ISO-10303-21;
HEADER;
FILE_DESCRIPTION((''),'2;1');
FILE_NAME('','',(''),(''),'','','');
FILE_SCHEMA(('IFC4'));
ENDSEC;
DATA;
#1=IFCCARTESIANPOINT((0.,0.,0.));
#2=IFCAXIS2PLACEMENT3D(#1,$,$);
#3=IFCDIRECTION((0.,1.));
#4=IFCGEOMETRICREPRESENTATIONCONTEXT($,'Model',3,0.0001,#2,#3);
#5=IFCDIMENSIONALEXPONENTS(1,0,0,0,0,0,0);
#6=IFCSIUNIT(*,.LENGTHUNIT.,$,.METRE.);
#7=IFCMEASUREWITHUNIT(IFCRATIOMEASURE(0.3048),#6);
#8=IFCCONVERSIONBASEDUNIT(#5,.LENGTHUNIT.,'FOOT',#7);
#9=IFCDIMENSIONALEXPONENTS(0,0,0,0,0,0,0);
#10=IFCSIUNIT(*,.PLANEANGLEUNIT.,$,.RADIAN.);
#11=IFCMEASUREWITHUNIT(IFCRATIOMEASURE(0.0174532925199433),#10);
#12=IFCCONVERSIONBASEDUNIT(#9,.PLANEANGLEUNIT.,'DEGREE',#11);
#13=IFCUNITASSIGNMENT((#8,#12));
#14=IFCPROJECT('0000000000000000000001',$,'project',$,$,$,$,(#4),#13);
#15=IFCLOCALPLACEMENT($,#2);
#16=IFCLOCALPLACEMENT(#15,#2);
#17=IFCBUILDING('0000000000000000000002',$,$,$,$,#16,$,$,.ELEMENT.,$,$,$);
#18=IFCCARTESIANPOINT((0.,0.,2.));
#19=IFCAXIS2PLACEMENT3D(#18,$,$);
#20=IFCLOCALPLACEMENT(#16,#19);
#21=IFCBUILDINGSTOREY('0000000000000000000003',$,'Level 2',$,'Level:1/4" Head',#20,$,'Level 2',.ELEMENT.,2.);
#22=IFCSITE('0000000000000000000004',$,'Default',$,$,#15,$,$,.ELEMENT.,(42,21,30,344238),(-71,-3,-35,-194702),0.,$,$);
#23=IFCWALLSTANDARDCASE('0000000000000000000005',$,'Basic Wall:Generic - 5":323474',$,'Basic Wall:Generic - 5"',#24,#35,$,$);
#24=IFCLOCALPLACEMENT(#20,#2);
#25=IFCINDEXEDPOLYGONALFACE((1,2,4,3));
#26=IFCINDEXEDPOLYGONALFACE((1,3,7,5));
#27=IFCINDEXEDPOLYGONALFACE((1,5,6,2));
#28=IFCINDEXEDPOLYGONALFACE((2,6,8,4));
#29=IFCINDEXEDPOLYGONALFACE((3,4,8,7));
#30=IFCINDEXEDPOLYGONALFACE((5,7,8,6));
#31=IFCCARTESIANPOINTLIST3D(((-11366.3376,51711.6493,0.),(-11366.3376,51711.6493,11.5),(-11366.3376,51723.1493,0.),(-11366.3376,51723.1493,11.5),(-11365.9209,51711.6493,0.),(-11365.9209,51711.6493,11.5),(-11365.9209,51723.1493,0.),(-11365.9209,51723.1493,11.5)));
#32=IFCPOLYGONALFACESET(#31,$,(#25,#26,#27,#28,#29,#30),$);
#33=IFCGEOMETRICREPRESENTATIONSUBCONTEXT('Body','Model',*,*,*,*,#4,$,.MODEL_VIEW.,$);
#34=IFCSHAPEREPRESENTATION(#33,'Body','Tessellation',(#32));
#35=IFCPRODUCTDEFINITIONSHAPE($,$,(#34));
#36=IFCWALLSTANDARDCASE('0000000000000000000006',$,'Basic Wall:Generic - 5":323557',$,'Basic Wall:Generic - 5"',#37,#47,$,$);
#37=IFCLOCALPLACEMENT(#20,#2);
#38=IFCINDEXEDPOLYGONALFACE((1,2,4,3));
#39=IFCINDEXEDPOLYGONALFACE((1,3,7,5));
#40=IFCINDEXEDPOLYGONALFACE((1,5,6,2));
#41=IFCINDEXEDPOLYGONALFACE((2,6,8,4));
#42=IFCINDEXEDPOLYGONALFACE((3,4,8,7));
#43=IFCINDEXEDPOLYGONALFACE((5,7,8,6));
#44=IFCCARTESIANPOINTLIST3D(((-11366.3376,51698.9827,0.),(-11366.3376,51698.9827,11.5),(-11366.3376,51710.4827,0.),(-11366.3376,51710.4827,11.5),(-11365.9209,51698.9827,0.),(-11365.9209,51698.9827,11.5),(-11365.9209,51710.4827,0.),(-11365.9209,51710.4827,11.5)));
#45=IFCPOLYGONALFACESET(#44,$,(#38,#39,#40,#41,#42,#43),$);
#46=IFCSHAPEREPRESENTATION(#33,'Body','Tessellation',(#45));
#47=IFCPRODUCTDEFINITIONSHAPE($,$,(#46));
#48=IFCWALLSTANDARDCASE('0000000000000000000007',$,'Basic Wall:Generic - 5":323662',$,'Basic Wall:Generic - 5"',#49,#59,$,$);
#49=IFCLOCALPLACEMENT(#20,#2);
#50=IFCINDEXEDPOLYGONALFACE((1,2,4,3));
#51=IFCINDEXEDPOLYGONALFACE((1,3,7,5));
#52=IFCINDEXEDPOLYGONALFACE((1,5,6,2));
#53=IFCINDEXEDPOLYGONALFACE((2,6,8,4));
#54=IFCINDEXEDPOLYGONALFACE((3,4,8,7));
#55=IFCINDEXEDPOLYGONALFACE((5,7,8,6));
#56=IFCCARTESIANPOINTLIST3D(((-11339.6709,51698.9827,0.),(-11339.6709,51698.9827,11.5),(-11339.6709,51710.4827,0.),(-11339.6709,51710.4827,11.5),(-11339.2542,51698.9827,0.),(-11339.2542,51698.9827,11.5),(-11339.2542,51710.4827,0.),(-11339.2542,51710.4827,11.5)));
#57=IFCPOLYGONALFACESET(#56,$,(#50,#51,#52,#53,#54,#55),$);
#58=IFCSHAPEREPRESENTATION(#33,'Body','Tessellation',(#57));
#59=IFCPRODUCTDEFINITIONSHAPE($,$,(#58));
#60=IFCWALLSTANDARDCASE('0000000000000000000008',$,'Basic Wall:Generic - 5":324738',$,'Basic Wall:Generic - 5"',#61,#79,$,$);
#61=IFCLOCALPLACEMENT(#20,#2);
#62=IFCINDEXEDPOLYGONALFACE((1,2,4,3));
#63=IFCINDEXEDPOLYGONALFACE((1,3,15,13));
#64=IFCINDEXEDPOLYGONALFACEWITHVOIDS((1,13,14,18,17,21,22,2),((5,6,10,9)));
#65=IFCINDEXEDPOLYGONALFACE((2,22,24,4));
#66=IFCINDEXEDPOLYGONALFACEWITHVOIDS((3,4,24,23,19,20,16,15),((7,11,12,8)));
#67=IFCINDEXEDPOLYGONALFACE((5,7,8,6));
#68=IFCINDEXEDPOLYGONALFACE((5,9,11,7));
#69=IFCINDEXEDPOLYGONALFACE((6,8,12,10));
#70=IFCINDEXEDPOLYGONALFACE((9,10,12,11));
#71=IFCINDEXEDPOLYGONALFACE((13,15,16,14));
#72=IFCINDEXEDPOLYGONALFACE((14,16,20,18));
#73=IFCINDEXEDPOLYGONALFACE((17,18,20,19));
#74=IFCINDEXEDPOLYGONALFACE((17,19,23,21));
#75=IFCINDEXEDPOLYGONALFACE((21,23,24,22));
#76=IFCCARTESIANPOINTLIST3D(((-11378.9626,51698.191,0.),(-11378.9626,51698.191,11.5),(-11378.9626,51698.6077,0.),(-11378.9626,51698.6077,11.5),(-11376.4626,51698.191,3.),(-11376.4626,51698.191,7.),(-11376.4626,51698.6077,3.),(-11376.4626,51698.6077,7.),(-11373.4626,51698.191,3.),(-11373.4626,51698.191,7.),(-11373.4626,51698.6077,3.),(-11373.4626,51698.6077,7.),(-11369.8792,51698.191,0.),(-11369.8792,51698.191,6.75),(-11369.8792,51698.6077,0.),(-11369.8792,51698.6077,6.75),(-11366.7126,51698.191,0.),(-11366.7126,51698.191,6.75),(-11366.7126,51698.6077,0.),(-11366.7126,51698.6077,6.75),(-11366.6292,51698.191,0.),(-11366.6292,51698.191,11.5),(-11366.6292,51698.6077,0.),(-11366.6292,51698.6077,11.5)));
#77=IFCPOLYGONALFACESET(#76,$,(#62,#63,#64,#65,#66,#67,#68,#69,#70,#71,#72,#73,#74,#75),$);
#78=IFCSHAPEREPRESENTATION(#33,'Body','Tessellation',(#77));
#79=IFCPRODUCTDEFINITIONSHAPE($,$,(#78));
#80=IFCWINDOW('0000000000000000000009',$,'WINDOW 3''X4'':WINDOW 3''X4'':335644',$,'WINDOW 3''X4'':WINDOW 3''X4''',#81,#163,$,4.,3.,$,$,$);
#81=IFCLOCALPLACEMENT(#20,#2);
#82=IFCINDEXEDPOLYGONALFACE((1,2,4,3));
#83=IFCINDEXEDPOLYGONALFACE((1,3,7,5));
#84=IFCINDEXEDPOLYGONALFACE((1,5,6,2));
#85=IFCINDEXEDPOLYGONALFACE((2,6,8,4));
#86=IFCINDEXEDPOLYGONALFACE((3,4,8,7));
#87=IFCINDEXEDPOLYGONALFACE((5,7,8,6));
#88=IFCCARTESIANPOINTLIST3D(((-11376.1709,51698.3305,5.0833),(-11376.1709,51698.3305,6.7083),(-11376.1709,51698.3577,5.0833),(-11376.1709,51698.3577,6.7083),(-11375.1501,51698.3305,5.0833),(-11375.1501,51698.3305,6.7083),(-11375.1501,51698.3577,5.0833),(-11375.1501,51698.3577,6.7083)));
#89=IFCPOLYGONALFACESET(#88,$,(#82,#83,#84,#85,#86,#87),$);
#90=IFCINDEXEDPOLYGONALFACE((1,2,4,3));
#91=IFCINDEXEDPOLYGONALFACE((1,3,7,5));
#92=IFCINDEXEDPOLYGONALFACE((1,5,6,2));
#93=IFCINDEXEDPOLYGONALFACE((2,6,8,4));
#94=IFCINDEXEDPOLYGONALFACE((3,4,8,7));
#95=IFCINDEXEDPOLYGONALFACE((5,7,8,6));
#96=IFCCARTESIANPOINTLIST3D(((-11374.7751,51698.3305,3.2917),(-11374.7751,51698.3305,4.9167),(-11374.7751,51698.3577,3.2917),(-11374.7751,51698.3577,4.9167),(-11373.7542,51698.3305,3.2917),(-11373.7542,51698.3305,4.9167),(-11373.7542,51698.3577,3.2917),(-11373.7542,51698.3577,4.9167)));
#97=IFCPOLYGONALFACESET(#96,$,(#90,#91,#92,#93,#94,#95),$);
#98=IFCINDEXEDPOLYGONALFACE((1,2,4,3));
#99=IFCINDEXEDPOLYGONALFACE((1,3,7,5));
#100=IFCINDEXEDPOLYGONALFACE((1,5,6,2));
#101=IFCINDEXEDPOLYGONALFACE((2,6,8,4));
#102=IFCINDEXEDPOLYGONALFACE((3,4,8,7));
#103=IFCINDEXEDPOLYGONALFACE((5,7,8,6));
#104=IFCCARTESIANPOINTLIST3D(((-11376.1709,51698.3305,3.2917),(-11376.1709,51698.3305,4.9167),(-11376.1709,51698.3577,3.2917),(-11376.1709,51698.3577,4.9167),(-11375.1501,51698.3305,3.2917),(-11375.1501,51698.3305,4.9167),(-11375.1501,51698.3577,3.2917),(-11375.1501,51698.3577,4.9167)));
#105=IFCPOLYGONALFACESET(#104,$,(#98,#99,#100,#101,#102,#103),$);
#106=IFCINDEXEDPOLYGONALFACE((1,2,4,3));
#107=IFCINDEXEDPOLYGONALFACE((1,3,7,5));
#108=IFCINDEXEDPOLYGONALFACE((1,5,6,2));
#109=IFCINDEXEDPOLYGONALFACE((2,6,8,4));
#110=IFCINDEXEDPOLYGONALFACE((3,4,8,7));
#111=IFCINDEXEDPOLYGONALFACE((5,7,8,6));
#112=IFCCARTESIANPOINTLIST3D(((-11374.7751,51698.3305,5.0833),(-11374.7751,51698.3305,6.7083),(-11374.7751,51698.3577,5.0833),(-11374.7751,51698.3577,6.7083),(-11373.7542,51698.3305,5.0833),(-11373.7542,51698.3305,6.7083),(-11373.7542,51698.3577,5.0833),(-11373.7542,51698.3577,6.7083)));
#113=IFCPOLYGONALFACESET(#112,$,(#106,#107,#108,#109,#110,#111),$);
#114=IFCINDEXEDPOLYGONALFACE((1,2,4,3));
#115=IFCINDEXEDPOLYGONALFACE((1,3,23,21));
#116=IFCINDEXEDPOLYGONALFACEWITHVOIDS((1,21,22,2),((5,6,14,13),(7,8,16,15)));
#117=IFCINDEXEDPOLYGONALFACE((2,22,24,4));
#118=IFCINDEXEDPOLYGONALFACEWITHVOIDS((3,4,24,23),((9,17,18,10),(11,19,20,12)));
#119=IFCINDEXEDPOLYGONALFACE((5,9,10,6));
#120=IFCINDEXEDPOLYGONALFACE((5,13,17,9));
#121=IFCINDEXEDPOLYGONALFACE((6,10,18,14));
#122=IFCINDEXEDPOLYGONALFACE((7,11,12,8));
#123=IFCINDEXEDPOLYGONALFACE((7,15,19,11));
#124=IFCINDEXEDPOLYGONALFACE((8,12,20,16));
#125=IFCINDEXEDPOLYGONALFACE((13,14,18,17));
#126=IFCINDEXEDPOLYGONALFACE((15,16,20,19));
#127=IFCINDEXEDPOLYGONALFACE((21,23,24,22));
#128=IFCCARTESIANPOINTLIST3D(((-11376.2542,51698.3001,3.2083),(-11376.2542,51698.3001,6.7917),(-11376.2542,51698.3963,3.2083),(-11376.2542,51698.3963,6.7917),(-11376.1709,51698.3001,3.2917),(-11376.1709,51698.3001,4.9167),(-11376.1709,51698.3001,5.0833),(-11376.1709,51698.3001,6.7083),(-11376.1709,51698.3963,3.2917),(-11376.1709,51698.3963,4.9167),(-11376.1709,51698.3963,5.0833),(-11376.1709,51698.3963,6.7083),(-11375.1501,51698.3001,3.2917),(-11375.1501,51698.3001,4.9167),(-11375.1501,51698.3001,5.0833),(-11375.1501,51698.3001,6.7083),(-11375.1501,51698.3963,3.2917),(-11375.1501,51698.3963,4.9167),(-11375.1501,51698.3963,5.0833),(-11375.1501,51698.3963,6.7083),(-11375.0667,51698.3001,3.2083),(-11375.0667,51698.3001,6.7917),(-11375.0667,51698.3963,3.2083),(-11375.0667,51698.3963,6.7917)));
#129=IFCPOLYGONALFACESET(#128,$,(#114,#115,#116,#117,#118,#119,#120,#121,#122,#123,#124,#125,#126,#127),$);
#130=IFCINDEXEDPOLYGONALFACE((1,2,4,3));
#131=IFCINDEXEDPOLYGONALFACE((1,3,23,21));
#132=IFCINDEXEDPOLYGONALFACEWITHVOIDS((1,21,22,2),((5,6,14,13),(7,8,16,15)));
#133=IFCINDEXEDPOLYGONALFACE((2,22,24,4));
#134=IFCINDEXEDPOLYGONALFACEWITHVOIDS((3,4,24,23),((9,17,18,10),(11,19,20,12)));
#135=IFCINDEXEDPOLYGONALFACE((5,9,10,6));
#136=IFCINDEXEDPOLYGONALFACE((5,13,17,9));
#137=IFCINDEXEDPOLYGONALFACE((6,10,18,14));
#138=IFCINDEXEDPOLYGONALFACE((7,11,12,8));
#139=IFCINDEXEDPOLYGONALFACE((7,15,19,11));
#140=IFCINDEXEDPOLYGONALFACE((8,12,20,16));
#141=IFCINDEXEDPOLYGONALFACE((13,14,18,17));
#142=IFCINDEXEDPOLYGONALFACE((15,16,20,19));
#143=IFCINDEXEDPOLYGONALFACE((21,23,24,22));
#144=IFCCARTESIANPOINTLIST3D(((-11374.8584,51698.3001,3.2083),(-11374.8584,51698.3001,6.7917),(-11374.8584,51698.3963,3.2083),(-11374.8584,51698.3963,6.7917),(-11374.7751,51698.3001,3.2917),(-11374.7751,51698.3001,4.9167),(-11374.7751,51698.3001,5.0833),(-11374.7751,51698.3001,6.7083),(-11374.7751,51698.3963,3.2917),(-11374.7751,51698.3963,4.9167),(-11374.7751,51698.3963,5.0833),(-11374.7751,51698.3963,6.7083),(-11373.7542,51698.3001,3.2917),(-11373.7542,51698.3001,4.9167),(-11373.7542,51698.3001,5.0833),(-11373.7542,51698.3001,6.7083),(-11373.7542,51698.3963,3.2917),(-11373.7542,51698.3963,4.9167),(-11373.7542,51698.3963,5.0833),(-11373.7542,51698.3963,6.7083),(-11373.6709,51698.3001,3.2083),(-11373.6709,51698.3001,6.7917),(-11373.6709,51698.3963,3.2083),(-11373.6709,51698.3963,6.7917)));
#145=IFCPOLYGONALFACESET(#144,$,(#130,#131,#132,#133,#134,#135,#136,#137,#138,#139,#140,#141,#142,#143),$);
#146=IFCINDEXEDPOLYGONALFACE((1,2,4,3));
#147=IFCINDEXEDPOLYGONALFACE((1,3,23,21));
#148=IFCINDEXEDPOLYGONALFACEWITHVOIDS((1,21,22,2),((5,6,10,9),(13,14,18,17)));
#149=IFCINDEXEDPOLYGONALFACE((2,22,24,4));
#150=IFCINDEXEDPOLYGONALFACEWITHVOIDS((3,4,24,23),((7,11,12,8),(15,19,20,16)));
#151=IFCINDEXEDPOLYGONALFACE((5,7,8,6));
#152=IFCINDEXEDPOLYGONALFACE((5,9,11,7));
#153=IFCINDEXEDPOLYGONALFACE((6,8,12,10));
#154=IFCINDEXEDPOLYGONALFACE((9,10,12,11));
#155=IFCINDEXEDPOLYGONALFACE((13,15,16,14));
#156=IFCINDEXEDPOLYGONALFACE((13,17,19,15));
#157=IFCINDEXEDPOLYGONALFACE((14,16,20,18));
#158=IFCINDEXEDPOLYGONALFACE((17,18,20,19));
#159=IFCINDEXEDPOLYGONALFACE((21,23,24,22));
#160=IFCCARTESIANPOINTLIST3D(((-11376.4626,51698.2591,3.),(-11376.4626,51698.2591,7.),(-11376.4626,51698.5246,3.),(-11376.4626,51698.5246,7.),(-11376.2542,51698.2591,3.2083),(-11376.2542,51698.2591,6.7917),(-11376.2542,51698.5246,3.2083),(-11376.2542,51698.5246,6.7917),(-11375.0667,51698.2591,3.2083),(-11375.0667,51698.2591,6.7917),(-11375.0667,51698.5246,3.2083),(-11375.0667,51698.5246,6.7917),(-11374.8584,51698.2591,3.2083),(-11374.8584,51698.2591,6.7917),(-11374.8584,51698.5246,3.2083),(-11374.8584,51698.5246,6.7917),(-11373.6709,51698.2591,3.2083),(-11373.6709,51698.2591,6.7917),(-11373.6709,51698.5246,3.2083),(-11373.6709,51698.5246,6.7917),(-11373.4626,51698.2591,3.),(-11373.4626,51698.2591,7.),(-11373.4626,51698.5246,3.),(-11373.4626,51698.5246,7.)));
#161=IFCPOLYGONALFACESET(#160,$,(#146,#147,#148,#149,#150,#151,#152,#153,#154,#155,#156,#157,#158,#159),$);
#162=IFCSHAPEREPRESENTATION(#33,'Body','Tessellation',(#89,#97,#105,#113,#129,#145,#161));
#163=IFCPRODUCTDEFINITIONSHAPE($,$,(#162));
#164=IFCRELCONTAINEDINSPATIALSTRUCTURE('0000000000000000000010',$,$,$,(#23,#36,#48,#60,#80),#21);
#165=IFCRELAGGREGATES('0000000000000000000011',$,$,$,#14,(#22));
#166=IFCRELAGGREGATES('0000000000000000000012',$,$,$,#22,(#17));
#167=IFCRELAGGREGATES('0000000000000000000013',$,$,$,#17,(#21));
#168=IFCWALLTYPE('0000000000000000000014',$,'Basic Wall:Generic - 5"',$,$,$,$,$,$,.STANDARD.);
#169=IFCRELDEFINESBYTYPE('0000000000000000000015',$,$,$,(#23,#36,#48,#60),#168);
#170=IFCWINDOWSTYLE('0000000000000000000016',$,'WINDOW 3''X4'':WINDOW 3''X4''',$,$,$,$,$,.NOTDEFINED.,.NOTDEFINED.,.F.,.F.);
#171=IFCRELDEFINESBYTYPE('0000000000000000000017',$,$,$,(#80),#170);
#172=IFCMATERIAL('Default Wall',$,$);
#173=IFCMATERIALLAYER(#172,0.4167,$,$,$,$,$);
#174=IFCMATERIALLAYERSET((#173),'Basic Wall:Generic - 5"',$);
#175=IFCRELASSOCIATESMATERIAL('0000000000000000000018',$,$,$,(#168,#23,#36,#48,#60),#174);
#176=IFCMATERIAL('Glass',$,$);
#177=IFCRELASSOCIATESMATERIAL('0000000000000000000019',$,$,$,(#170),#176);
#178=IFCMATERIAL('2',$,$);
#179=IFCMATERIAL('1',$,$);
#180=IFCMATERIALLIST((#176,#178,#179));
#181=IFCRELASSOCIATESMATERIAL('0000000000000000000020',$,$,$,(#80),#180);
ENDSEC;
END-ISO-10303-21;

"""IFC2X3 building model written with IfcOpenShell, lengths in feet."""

from ifc_helpers import new_model, entity, si_unit, converted_unit, direction, frame, frame_2d, origin, origin_2d_with_axis, place, context, subcontext, project, spatial, polyline, rectangle, outline, extrude, source, transform, mapped, material, material_list, layer, layer_set, layer_usage, type_object, type_shapes, element, fill, save


model = new_model("IFC2X3")

# Units and contexts
model_context = context("Model", 3, precision=0.0001, world=origin(), true_north=direction((0.0, 1.0)))
body_context = subcontext(model_context, "Body", "Model", "MODEL_VIEW")
ifc_project = project(units=[converted_unit("LENGTHUNIT", "FOOT", entity("IfcRatioMeasure", 0.3048), si_unit("LENGTHUNIT", "METRE"), dimensions=[1, 0, 0, 0, 0, 0, 0]), converted_unit("PLANEANGLEUNIT", "DEGREE", entity("IfcRatioMeasure", 0.0174532925199433), si_unit("PLANEANGLEUNIT", "RADIAN"), dimensions=[0, 0, 0, 0, 0, 0, 0])], contexts=[model_context])

# Site, building, storey
site_placement = place(None, origin())
site = spatial("IfcSite", under=ifc_project, at=site_placement, Name="Default", CompositionType="ELEMENT", RefLatitude=(42, 21, 30, 344238), RefLongitude=(-71, -3, -35, -194702), RefElevation=0.0)
building_placement = place(site_placement, origin())
building = spatial("IfcBuilding", under=site, at=building_placement, CompositionType="ELEMENT")
storey_placement = place(building_placement, frame((0.0, 0.0, 2.0)))
storey = spatial("IfcBuildingStorey", under=building, at=storey_placement, Name="Level 2", ObjectType="Level:1/4\" Head", LongName="Level 2", CompositionType="ELEMENT", Elevation=2.0)

# Shared definitions
ifc_material_1 = material(Name="Default Wall")
ifc_material_2 = material(Name="Glass")
ifc_material_3 = material(Name="2")
ifc_material_4 = material(Name="1")
ifc_layer_1 = layer(ifc_material_1, 0.4167)
ifc_layer_set_1 = layer_set([ifc_layer_1], Name="Basic Wall:Generic - 5\"")
wall_type_1 = type_object("IfcWallType", Name="Basic Wall:Generic - 5\"", PredefinedType="STANDARD", material=ifc_layer_set_1)

# Walls
ifc_layer_usage_1 = layer_usage(ifc_layer_set_1, "AXIS2", "NEGATIVE", 0.2083)
wall_1_placement = place(storey_placement, frame((-11366.1292, 51723.1493, 0.0), z_axis=(0.0, 0.0, 1.0), x_axis=(0.0, -1.0, 0.0)))
element("IfcWallStandardCase", 1, at=wall_1_placement, inside=storey, type_object=wall_type_1, material=ifc_layer_usage_1, Name="Basic Wall:Generic - 5\":323474", ObjectType="Basic Wall:Generic - 5\"", context=body_context, shape_type="SweptSolid", body=[
    extrude(rectangle(XDim=11.5, YDim=0.4167, at=frame_2d((5.75, 0.0), x_axis=(-1.0, 0.0))), origin(), (0.0, 0.0, 1.0), 11.5),
])
ifc_layer_usage_2 = layer_usage(ifc_layer_set_1, "AXIS2", "NEGATIVE", 0.2083)
wall_2_placement = place(storey_placement, frame((-11366.1292, 51710.4827, 0.0), z_axis=(0.0, 0.0, 1.0), x_axis=(0.0, -1.0, 0.0)))
element("IfcWallStandardCase", 2, at=wall_2_placement, inside=storey, type_object=wall_type_1, material=ifc_layer_usage_2, Name="Basic Wall:Generic - 5\":323557", ObjectType="Basic Wall:Generic - 5\"", context=body_context, shape_type="SweptSolid", body=[
    extrude(rectangle(XDim=11.5, YDim=0.4167, at=frame_2d((5.75, 0.0), x_axis=(-1.0, 0.0))), origin(), (0.0, 0.0, 1.0), 11.5),
])
ifc_layer_usage_3 = layer_usage(ifc_layer_set_1, "AXIS2", "NEGATIVE", 0.2083)
wall_3_placement = place(storey_placement, frame((-11339.4626, 51710.4827, 0.0), z_axis=(0.0, 0.0, 1.0), x_axis=(0.0, -1.0, 0.0)))
element("IfcWallStandardCase", 3, at=wall_3_placement, inside=storey, type_object=wall_type_1, material=ifc_layer_usage_3, Name="Basic Wall:Generic - 5\":323662", ObjectType="Basic Wall:Generic - 5\"", context=body_context, shape_type="SweptSolid", body=[
    extrude(rectangle(XDim=11.5, YDim=0.4167, at=frame_2d((5.75, 0.0), x_axis=(-1.0, 0.0))), origin(), (0.0, 0.0, 1.0), 11.5),
])

# Wall, openings, window
ifc_layer_usage_4 = layer_usage(ifc_layer_set_1, "AXIS2", "NEGATIVE", 0.2083)
wall_4_placement = place(storey_placement, frame((-11378.9626, 51698.3993, 0.0)))
wall_4 = element("IfcWallStandardCase", 4, at=wall_4_placement, inside=storey, type_object=wall_type_1, material=ifc_layer_usage_4, Name="Basic Wall:Generic - 5\":324738", ObjectType="Basic Wall:Generic - 5\"", context=body_context, shape_type="SweptSolid", body=[
    extrude(rectangle(XDim=12.3333, YDim=0.4167, at=frame_2d((6.1667, 0.0), x_axis=(-1.0, 0.0))), origin(), (0.0, 0.0, 1.0), 11.5),
])
opening_1_placement = place(wall_4_placement, frame((9.0833, -0.2083, 0.0)))
element("IfcOpeningElement", 5, at=opening_1_placement, cuts=wall_4, ObjectType="Opening", context=body_context, shape_type="SweptSolid", body=[
    extrude(rectangle(XDim=6.75, YDim=3.1667, at=frame_2d((3.375, 1.5833), x_axis=(1.0, 0.0))), frame((0.0, 0.0, 0.0), z_axis=(0.0, 1.0, 0.0), x_axis=(0.0, 0.0, 1.0)), (0.0, 0.0, 1.0), 0.4167),
])
opening_2_placement = place(wall_4_placement, frame((5.5, 0.2083, 3.0)))
opening_2 = element("IfcOpeningElement", 6, at=opening_2_placement, cuts=wall_4, ObjectType="Opening", context=body_context, shape_type="SweptSolid", body=[
    extrude(rectangle(XDim=4.0, YDim=3.0, at=frame_2d((2.0, 1.5), x_axis=(-1.0, 0.0))), frame((0.0, 0.0, 0.0), z_axis=(0.0, -1.0, 0.0), x_axis=(0.0, 0.0, 1.0)), (0.0, 0.0, 1.0), 0.4167),
])
ifc_material_list_1 = material_list([ifc_material_2, ifc_material_3, ifc_material_4])
window_style_1 = type_object("IfcWindowStyle", Name="WINDOW 3'X4':WINDOW 3'X4'", ConstructionType="NOTDEFINED", OperationType="NOTDEFINED", ParameterTakesPrecedence=False, Sizeable=False, material=ifc_material_2)
shared_shape_1 = source(origin(), body_context, "Body", "SweptSolid", [
    extrude(rectangle(XDim=0.0272, YDim=1.0208, at=origin_2d_with_axis()), frame((2.1979, 0.2636, 2.0833), z_axis=(0.0, 0.0, 1.0), x_axis=(0.0, 1.0, 0.0)), (0.0, 0.0, 1.0), 1.625),
    extrude(rectangle(XDim=0.0272, YDim=1.0208, at=origin_2d_with_axis()), frame((0.8021, 0.2636, 0.2917), z_axis=(0.0, 0.0, 1.0), x_axis=(0.0, 1.0, 0.0)), (0.0, 0.0, 1.0), 1.625),
    extrude(rectangle(XDim=0.0272, YDim=1.0208, at=origin_2d_with_axis()), frame((2.1979, 0.2636, 0.2917), z_axis=(0.0, 0.0, 1.0), x_axis=(0.0, 1.0, 0.0)), (0.0, 0.0, 1.0), 1.625),
    extrude(rectangle(XDim=0.0272, YDim=1.0208, at=origin_2d_with_axis()), frame((0.8021, 0.2636, 2.0833), z_axis=(0.0, 0.0, 1.0), x_axis=(0.0, 1.0, 0.0)), (0.0, 0.0, 1.0), 1.625),
    extrude(outline(polyline([(-0.5938, -1.7917), (0.5938, -1.7917), (0.5938, 1.7917), (-0.5938, 1.7917), (-0.5938, -1.7917)]), holes=[polyline([(-0.5104, -0.0833), (0.5104, -0.0833), (0.5104, -1.7083), (-0.5104, -1.7083), (-0.5104, -0.0833)]), polyline([(-0.5104, 1.7083), (0.5104, 1.7083), (0.5104, 0.0833), (-0.5104, 0.0833), (-0.5104, 1.7083)])]), frame((2.1979, 0.2114, 2.0), z_axis=(0.0, 1.0, 0.0), x_axis=(-1.0, 0.0, 0.0)), (0.0, 0.0, 1.0), 0.0962),
    extrude(outline(polyline([(-1.7917, -0.5937), (1.7917, -0.5937), (1.7917, 0.5937), (-1.7917, 0.5937), (-1.7917, -0.5937)]), holes=[polyline([(0.0833, -0.5104), (0.0833, 0.5104), (1.7083, 0.5104), (1.7083, -0.5104), (0.0833, -0.5104)]), polyline([(-1.7083, -0.5104), (-1.7083, 0.5104), (-0.0833, 0.5104), (-0.0833, -0.5104), (-1.7083, -0.5104)])]), frame((0.8021, 0.2114, 2.0), z_axis=(0.0, 1.0, 0.0), x_axis=(0.0, 0.0, -1.0)), (0.0, 0.0, 1.0), 0.0962),
    extrude(outline(polyline([(-1.5, -2.0), (1.5, -2.0), (1.5, 2.0), (-1.5, 2.0), (-1.5, -2.0)]), holes=[polyline([(-0.1042, 1.7917), (-0.1042, -1.7917), (-1.2917, -1.7917), (-1.2917, 1.7917), (-0.1042, 1.7917)]), polyline([(0.1042, -1.7917), (0.1042, 1.7917), (1.2917, 1.7917), (1.2917, -1.7917), (0.1042, -1.7917)])]), frame((1.5, 0.0831, 2.0), z_axis=(0.0, 1.0, 0.0), x_axis=(1.0, 0.0, 0.0)), (0.0, 0.0, 1.0), 0.2655),
])
type_shapes(window_style_1, [shared_shape_1])
window_1_placement = place(opening_2_placement, frame((0.0, 0.0, 0.0), z_axis=(0.0, 0.0, 1.0), x_axis=(-1.0, 0.0, 0.0)))
window_1 = element("IfcWindow", 7, at=window_1_placement, inside=storey, type_object=window_style_1, material=ifc_material_list_1, Name="WINDOW 3'X4':WINDOW 3'X4':335644", ObjectType="WINDOW 3'X4':WINDOW 3'X4'", OverallHeight=4.0, OverallWidth=3.0, context=body_context, shape_type="MappedRepresentation", body=[
    mapped(shared_shape_1, transform((0.0, 0.0, 0.0), scale=1.0)),
])
fill(opening_2, window_1)

save(model, "model.ifc")
